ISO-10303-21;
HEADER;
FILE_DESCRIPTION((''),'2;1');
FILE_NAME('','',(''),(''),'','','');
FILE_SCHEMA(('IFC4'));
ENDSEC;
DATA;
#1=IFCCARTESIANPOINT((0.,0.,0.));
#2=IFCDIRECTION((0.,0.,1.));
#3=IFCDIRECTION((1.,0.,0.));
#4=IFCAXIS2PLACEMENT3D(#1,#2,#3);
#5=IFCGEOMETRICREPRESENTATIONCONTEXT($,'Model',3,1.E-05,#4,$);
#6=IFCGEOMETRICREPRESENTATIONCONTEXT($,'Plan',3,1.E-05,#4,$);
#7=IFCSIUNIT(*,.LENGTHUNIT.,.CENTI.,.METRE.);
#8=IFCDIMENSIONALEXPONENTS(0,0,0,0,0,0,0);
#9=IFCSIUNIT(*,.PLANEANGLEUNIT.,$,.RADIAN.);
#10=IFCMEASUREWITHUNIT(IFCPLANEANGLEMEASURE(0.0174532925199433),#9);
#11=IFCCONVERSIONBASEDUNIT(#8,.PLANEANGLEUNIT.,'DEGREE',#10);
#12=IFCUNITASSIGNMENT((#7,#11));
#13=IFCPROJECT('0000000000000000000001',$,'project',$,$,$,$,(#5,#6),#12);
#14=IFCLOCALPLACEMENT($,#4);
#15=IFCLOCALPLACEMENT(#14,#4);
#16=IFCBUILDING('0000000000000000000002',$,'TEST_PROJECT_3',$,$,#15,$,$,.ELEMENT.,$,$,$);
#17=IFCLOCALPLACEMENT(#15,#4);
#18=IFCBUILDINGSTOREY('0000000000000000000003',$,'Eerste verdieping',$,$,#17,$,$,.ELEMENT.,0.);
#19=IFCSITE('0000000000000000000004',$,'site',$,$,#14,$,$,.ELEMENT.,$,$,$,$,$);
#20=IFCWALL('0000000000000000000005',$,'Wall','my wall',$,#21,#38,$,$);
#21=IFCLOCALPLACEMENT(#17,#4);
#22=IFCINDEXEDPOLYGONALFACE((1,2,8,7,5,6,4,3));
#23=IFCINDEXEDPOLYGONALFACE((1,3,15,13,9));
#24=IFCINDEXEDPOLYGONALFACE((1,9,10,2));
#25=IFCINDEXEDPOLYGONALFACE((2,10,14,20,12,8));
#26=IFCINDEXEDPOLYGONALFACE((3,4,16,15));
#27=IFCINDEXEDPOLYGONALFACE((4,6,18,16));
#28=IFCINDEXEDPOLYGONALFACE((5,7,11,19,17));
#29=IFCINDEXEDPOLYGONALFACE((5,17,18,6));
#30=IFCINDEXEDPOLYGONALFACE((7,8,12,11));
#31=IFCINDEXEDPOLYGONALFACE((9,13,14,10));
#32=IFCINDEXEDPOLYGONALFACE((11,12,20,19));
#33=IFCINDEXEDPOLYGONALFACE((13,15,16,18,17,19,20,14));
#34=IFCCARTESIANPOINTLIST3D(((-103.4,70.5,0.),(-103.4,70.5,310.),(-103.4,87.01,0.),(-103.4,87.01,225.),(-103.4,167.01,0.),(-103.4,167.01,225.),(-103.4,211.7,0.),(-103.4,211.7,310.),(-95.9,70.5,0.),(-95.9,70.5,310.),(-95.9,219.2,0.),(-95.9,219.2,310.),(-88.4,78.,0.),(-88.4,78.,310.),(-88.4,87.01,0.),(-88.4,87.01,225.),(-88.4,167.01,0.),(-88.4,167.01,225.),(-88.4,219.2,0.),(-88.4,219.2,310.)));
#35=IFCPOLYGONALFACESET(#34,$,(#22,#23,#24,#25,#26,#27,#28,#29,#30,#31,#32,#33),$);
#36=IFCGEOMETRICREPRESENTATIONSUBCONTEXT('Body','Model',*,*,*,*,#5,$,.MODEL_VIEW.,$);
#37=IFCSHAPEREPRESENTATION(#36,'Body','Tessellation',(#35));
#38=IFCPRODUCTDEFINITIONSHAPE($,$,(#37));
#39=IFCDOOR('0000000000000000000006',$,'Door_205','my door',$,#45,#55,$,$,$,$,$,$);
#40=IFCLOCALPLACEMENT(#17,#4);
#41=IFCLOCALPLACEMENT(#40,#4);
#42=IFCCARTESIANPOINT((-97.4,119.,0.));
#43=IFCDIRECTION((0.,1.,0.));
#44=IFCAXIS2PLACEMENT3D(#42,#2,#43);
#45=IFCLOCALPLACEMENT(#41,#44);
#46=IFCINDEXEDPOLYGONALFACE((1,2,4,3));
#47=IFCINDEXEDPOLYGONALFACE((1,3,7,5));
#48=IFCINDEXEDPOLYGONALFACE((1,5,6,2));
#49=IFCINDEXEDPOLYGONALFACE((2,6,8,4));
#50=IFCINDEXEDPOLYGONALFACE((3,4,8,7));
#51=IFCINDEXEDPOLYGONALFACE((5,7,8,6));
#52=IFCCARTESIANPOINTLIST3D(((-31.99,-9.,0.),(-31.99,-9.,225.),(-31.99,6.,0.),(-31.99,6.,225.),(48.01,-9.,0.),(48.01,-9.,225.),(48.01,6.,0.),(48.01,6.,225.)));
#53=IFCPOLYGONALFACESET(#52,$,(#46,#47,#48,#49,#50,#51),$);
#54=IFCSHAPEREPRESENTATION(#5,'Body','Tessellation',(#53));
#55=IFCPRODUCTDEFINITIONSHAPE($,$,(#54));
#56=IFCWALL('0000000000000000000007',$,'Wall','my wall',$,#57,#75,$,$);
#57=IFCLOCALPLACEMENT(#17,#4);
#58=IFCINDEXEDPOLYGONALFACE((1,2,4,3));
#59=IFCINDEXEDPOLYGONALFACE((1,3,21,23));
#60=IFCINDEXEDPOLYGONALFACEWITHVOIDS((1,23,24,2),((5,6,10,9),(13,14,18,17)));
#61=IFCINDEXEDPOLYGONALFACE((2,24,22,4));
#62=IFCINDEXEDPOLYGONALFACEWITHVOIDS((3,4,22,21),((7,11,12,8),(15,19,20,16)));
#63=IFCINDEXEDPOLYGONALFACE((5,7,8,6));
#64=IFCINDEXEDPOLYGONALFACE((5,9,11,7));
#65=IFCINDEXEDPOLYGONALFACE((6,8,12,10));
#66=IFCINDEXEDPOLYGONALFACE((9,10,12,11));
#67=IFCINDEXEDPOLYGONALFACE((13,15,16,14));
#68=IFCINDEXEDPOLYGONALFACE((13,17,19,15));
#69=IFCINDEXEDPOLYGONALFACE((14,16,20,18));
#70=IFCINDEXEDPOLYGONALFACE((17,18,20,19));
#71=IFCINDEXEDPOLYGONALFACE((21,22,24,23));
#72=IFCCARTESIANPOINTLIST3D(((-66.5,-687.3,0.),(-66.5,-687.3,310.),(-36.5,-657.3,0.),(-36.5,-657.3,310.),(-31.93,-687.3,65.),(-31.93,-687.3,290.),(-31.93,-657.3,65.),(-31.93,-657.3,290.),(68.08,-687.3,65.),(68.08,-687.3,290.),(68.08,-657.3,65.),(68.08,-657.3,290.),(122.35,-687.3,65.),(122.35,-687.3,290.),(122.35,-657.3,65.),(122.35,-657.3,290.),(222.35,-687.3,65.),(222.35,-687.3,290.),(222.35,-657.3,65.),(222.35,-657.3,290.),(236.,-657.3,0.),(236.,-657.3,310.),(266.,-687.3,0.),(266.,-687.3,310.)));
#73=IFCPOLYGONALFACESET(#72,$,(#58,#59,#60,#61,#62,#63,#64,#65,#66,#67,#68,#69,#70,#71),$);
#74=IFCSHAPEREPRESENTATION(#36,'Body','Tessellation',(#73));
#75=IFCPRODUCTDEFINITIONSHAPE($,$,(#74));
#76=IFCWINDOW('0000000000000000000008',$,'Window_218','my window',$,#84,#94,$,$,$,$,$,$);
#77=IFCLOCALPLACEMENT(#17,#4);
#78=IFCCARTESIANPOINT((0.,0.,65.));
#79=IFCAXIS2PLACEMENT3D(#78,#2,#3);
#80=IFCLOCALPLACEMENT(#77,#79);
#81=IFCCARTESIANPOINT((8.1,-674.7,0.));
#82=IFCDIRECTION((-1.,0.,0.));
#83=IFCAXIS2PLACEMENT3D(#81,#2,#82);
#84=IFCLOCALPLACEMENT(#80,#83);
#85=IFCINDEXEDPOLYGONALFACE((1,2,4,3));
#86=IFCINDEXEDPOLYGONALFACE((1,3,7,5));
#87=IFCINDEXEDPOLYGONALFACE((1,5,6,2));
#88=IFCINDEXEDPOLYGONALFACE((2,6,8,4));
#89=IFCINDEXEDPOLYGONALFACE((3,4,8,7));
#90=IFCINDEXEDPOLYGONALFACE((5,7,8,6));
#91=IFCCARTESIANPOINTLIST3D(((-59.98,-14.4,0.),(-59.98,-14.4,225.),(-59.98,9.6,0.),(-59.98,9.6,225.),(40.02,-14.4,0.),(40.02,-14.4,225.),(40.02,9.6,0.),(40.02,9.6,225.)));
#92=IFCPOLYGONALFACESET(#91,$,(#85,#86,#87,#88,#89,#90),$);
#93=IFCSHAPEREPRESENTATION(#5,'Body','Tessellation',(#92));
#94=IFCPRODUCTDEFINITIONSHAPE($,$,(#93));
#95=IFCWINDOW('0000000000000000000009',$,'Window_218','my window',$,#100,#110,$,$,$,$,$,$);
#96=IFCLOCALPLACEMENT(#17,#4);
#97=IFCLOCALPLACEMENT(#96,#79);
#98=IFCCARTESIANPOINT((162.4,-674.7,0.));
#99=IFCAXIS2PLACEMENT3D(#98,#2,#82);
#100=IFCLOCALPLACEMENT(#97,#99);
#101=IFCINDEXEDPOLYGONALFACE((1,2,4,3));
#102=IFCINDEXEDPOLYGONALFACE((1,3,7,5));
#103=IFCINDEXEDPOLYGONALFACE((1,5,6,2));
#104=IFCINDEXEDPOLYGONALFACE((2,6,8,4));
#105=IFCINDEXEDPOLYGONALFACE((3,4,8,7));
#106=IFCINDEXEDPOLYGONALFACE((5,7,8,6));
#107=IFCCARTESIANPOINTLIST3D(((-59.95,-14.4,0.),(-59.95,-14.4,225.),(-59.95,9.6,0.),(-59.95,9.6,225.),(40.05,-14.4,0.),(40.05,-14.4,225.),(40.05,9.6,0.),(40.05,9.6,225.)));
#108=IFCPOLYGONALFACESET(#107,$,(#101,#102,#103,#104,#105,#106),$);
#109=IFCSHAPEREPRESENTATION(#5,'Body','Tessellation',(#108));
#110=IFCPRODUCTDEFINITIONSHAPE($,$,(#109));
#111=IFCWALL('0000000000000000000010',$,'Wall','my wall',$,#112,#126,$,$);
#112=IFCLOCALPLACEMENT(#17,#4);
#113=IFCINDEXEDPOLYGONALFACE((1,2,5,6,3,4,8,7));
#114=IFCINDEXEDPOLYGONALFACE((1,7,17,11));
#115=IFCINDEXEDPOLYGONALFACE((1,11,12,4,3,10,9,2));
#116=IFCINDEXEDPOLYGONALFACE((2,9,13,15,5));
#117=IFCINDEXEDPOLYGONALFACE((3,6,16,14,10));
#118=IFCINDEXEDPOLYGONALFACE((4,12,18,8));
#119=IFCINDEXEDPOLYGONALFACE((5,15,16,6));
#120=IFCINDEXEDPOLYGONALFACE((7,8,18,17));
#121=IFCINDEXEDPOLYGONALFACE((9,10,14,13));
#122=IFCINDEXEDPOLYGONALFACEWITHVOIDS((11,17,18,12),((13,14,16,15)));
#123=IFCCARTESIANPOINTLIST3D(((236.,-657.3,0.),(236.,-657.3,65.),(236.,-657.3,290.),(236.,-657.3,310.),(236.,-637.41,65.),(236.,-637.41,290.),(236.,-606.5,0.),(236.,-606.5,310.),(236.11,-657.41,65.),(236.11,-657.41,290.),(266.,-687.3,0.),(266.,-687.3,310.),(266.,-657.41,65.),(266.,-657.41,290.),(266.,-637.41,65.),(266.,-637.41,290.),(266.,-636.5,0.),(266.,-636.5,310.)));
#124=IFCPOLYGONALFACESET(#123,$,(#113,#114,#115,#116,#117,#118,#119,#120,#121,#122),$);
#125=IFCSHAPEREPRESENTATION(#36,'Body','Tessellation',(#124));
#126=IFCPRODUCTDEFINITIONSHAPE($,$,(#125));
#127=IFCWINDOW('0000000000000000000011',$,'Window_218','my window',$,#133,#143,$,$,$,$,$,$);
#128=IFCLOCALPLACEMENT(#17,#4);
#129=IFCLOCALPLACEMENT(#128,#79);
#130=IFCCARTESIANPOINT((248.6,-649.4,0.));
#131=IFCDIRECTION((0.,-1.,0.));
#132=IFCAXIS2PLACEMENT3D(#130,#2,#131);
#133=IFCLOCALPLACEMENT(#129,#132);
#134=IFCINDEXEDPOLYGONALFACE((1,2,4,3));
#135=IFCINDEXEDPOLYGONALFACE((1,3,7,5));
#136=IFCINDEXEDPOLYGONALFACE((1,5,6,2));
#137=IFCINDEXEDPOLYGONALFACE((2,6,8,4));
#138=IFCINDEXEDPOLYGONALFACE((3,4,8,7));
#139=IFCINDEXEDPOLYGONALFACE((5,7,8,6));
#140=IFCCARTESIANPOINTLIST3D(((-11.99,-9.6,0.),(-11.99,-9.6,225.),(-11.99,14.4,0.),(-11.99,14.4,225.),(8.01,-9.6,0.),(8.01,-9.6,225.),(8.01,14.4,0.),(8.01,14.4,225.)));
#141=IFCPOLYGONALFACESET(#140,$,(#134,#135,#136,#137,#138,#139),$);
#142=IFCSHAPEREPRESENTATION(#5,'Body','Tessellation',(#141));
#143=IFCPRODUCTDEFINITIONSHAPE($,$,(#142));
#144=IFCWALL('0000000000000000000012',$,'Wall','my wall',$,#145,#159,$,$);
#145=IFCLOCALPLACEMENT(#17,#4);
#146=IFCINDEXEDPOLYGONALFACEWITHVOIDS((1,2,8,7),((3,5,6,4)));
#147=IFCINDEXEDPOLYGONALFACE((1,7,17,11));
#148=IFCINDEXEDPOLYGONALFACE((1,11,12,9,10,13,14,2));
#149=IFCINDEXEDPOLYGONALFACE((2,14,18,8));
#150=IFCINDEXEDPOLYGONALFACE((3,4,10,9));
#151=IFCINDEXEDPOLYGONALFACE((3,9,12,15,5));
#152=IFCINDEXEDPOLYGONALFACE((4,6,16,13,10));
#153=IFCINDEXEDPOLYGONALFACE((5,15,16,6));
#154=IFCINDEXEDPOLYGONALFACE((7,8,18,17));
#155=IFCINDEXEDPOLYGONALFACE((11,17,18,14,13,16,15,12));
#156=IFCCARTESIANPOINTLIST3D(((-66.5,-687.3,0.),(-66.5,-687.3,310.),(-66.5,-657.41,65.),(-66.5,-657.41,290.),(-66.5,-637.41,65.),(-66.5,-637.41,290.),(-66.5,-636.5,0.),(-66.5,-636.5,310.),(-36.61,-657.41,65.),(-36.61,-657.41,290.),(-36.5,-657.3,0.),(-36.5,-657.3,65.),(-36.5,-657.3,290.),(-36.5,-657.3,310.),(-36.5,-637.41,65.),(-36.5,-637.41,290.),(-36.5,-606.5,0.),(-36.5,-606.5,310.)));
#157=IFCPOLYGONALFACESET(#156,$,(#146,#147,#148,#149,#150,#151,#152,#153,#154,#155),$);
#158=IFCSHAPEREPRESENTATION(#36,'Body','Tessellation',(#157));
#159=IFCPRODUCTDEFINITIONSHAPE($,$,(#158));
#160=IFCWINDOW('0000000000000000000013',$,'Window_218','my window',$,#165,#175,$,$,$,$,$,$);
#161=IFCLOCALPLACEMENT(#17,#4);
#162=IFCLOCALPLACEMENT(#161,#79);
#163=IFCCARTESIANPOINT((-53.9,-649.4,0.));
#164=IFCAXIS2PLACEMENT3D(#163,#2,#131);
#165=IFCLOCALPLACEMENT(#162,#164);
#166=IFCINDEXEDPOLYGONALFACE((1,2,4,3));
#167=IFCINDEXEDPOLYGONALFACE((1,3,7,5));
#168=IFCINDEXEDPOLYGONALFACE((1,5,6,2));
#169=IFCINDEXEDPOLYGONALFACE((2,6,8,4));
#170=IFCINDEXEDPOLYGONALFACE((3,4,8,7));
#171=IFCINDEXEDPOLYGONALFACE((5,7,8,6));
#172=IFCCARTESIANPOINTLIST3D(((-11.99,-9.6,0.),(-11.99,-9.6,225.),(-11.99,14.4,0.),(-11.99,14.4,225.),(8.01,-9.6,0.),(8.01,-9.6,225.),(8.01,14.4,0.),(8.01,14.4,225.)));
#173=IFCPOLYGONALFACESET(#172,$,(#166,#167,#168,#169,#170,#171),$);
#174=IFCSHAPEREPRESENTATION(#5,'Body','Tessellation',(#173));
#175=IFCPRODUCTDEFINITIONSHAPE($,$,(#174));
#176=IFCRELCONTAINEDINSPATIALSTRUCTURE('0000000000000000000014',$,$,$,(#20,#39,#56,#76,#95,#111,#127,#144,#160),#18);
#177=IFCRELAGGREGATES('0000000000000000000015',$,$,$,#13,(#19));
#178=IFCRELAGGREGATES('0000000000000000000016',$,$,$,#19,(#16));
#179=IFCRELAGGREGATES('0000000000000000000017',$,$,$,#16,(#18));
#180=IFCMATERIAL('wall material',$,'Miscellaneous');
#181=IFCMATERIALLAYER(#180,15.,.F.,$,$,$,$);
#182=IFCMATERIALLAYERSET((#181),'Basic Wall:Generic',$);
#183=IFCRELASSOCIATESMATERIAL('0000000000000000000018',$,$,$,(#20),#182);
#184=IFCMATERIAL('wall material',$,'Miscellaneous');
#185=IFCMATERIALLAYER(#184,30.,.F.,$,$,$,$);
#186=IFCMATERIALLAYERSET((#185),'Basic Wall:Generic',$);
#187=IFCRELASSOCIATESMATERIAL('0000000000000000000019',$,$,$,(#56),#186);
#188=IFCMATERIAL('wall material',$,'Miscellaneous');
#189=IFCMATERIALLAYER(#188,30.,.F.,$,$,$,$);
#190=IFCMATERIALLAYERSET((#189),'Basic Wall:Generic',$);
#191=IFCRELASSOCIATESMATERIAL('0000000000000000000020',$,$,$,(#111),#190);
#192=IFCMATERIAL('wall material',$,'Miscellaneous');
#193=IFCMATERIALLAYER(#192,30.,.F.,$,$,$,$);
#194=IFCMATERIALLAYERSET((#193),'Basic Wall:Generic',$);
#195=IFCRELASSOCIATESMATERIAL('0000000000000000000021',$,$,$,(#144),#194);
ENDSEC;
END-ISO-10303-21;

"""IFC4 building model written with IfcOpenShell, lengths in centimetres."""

from ifc_helpers import new_model, entity, si_unit, converted_unit, frame, origin_with_axes, place, context, subcontext, project, spatial, polyline, outline, extrude, material, layer, layer_set, layer_usage, element, fill, save


model = new_model("IFC4")

# Units and contexts
model_context = context("Model", 3, precision=1e-05, world=origin_with_axes())
plan_context = context("Plan", 3, precision=1e-05, world=origin_with_axes())
body_context = subcontext(model_context, "Body", "Model", "MODEL_VIEW")
ifc_project = project(units=[si_unit("LENGTHUNIT", "METRE", prefix="CENTI"), converted_unit("PLANEANGLEUNIT", "DEGREE", entity("IfcPlaneAngleMeasure", 0.0174532925199433), si_unit("PLANEANGLEUNIT", "RADIAN"), dimensions=[0, 0, 0, 0, 0, 0, 0])], contexts=[model_context, plan_context])

# Site, building, storey
site_placement = place(None, origin_with_axes())
site = spatial("IfcSite", under=ifc_project, at=site_placement, Name="site", CompositionType="ELEMENT")
building_placement = place(site_placement, origin_with_axes())
building = spatial("IfcBuilding", under=site, at=building_placement, Name="TEST_PROJECT_3", CompositionType="ELEMENT")
storey_placement = place(building_placement, origin_with_axes())
storey = spatial("IfcBuildingStorey", under=building, at=storey_placement, Name="Eerste verdieping", CompositionType="ELEMENT", Elevation=0.0)

# Wall, opening, door
ifc_material_1 = material(Name="wall material", Category="Miscellaneous")
ifc_layer_1 = layer(ifc_material_1, 15.0, ventilated=False)
ifc_layer_set_1 = layer_set([ifc_layer_1], Name="Basic Wall:Generic")
ifc_layer_usage_1 = layer_usage(ifc_layer_set_1, "AXIS3", "NEGATIVE", 0.0)
wall_1_placement = place(storey_placement, origin_with_axes())
wall_1 = element("IfcWall", 1, at=wall_1_placement, inside=storey, material=ifc_layer_usage_1, Name="Wall", Description="my wall", context=body_context, shape_type="SweptSolid", body=[
    extrude(outline(polyline([(-95.9, 70.5, 0.0), (-103.4, 70.5, 0.0), (-103.4, 211.7, 0.0), (-95.9, 219.2, 0.0), (-88.4, 219.2, 0.0), (-88.4, 78.0, 0.0), (-95.9, 70.5, 0.0)])), origin_with_axes(), (0.0, 0.0, 1.0), 310.0),
])
placement_1 = place(storey_placement, origin_with_axes())
opening_1_placement = place(placement_1, origin_with_axes())
opening_1 = element("IfcOpeningElement", 2, at=opening_1_placement, cuts=wall_1, context=model_context, shape_type="SweptSolid", body=[
    extrude(outline(polyline([(-103.4, 87.01, 0.0), (-103.4, 167.01, 0.0), (-88.4, 167.01, 0.0), (-88.4, 87.01, 0.0), (-103.4, 87.01, 0.0)])), origin_with_axes(), (0.0, 0.0, 1.0), 225.0),
])
door_1_placement = place(opening_1_placement, frame((-97.4, 119.0, 0.0), z_axis=(0.0, 0.0, 1.0), x_axis=(0.0, 1.0, 0.0)))
door_1 = element("IfcDoor", 3, at=door_1_placement, inside=storey, Name="Door_205", Description="my door", context=model_context, shape_type="SweptSolid", body=[
    extrude(outline(polyline([(-31.99, 6.0), (48.01, 6.0), (48.01, -9.0), (-31.99, -9.0), (-31.99, 6.0)])), origin_with_axes(), (0.0, 0.0, 1.0), 225.0),
])
fill(opening_1, door_1)

# Wall, openings, windows
ifc_material_2 = material(Name="wall material", Category="Miscellaneous")
ifc_layer_2 = layer(ifc_material_2, 30.0, ventilated=False)
ifc_layer_set_2 = layer_set([ifc_layer_2], Name="Basic Wall:Generic")
ifc_layer_usage_2 = layer_usage(ifc_layer_set_2, "AXIS3", "NEGATIVE", 0.0)
wall_2_placement = place(storey_placement, origin_with_axes())
wall_2 = element("IfcWall", 4, at=wall_2_placement, inside=storey, material=ifc_layer_usage_2, Name="Wall", Description="my wall", context=body_context, shape_type="SweptSolid", body=[
    extrude(outline(polyline([(-66.5, -687.3, 0.0), (-36.5, -657.3, 0.0), (236.0, -657.3, 0.0), (266.0, -687.3, 0.0), (-66.5, -687.3, 0.0)])), origin_with_axes(), (0.0, 0.0, 1.0), 310.0),
])
placement_2 = place(storey_placement, origin_with_axes())
opening_2_placement = place(placement_2, frame((0.0, 0.0, 65.0), z_axis=(0.0, 0.0, 1.0), x_axis=(1.0, 0.0, 0.0)))
opening_2 = element("IfcOpeningElement", 5, at=opening_2_placement, cuts=wall_2, context=model_context, shape_type="SweptSolid", body=[
    extrude(outline(polyline([(-31.93, -687.3, 0.0), (-31.93, -657.3, 0.0), (68.08, -657.3, 0.0), (68.08, -687.3, 0.0), (-31.93, -687.3, 0.0)])), origin_with_axes(), (0.0, 0.0, 1.0), 225.0),
])
placement_3 = place(storey_placement, origin_with_axes())
opening_3_placement = place(placement_3, frame((0.0, 0.0, 65.0), z_axis=(0.0, 0.0, 1.0), x_axis=(1.0, 0.0, 0.0)))
opening_3 = element("IfcOpeningElement", 6, at=opening_3_placement, cuts=wall_2, context=model_context, shape_type="SweptSolid", body=[
    extrude(outline(polyline([(122.35, -687.3, 0.0), (122.35, -657.3, 0.0), (222.35, -657.3, 0.0), (222.35, -687.3, 0.0), (122.35, -687.3, 0.0)])), origin_with_axes(), (0.0, 0.0, 1.0), 225.0),
])
window_1_placement = place(opening_2_placement, frame((8.1, -674.7, 0.0), z_axis=(0.0, 0.0, 1.0), x_axis=(-1.0, 0.0, 0.0)))
window_1 = element("IfcWindow", 7, at=window_1_placement, inside=storey, Name="Window_218", Description="my window", context=model_context, shape_type="SweptSolid", body=[
    extrude(outline(polyline([(40.02, 9.6), (40.02, -14.4), (-59.98, -14.4), (-59.98, 9.6), (40.02, 9.6)])), origin_with_axes(), (0.0, 0.0, 1.0), 225.0),
])
fill(opening_2, window_1)
window_2_placement = place(opening_3_placement, frame((162.4, -674.7, 0.0), z_axis=(0.0, 0.0, 1.0), x_axis=(-1.0, 0.0, 0.0)))
window_2 = element("IfcWindow", 8, at=window_2_placement, inside=storey, Name="Window_218", Description="my window", context=model_context, shape_type="SweptSolid", body=[
    extrude(outline(polyline([(40.05, 9.6), (40.05, -14.4), (-59.95, -14.4), (-59.95, 9.6), (40.05, 9.6)])), origin_with_axes(), (0.0, 0.0, 1.0), 225.0),
])
fill(opening_3, window_2)

# Walls, openings, windows
ifc_material_3 = material(Name="wall material", Category="Miscellaneous")
ifc_layer_3 = layer(ifc_material_3, 30.0, ventilated=False)
ifc_layer_set_3 = layer_set([ifc_layer_3], Name="Basic Wall:Generic")
ifc_layer_usage_3 = layer_usage(ifc_layer_set_3, "AXIS3", "NEGATIVE", 0.0)
wall_3_placement = place(storey_placement, origin_with_axes())
wall_3 = element("IfcWall", 9, at=wall_3_placement, inside=storey, material=ifc_layer_usage_3, Name="Wall", Description="my wall", context=body_context, shape_type="SweptSolid", body=[
    extrude(outline(polyline([(236.0, -657.3, 0.0), (236.0, -606.5, 0.0), (266.0, -636.5, 0.0), (266.0, -687.3, 0.0), (236.0, -657.3, 0.0)])), origin_with_axes(), (0.0, 0.0, 1.0), 310.0),
])
placement_4 = place(storey_placement, origin_with_axes())
opening_4_placement = place(placement_4, frame((0.0, 0.0, 65.0), z_axis=(0.0, 0.0, 1.0), x_axis=(1.0, 0.0, 0.0)))
opening_4 = element("IfcOpeningElement", 10, at=opening_4_placement, cuts=wall_3, context=model_context, shape_type="SweptSolid", body=[
    extrude(outline(polyline([(236.0, -657.41, 0.0), (236.0, -637.41, 0.0), (266.0, -637.41, 0.0), (266.0, -657.41, 0.0), (236.0, -657.41, 0.0)])), origin_with_axes(), (0.0, 0.0, 1.0), 225.0),
])
window_3_placement = place(opening_4_placement, frame((248.6, -649.4, 0.0), z_axis=(0.0, 0.0, 1.0), x_axis=(0.0, -1.0, 0.0)))
window_3 = element("IfcWindow", 11, at=window_3_placement, inside=storey, Name="Window_218", Description="my window", context=model_context, shape_type="SweptSolid", body=[
    extrude(outline(polyline([(8.01, -9.6), (-11.99, -9.6), (-11.99, 14.4), (8.01, 14.4), (8.01, -9.6)])), origin_with_axes(), (0.0, 0.0, 1.0), 225.0),
])
fill(opening_4, window_3)
ifc_material_4 = material(Name="wall material", Category="Miscellaneous")
ifc_layer_4 = layer(ifc_material_4, 30.0, ventilated=False)
ifc_layer_set_4 = layer_set([ifc_layer_4], Name="Basic Wall:Generic")
ifc_layer_usage_4 = layer_usage(ifc_layer_set_4, "AXIS3", "NEGATIVE", 0.0)
wall_4_placement = place(storey_placement, origin_with_axes())
wall_4 = element("IfcWall", 12, at=wall_4_placement, inside=storey, material=ifc_layer_usage_4, Name="Wall", Description="my wall", context=body_context, shape_type="SweptSolid", body=[
    extrude(outline(polyline([(-66.5, -687.3, 0.0), (-66.5, -636.5, 0.0), (-36.5, -606.5, 0.0), (-36.5, -657.3, 0.0), (-66.5, -687.3, 0.0)])), origin_with_axes(), (0.0, 0.0, 1.0), 310.0),
])
placement_5 = place(storey_placement, origin_with_axes())
opening_5_placement = place(placement_5, frame((0.0, 0.0, 65.0), z_axis=(0.0, 0.0, 1.0), x_axis=(1.0, 0.0, 0.0)))
opening_5 = element("IfcOpeningElement", 13, at=opening_5_placement, cuts=wall_4, context=model_context, shape_type="SweptSolid", body=[
    extrude(outline(polyline([(-66.5, -657.41, 0.0), (-66.5, -637.41, 0.0), (-36.5, -637.41, 0.0), (-36.5, -657.41, 0.0), (-66.5, -657.41, 0.0)])), origin_with_axes(), (0.0, 0.0, 1.0), 225.0),
])
window_4_placement = place(opening_5_placement, frame((-53.9, -649.4, 0.0), z_axis=(0.0, 0.0, 1.0), x_axis=(0.0, -1.0, 0.0)))
window_4 = element("IfcWindow", 14, at=window_4_placement, inside=storey, Name="Window_218", Description="my window", context=model_context, shape_type="SweptSolid", body=[
    extrude(outline(polyline([(8.01, -9.6), (-11.99, -9.6), (-11.99, 14.4), (8.01, 14.4), (8.01, -9.6)])), origin_with_axes(), (0.0, 0.0, 1.0), 225.0),
])
fill(opening_5, window_4)

save(model, "model.ifc")
